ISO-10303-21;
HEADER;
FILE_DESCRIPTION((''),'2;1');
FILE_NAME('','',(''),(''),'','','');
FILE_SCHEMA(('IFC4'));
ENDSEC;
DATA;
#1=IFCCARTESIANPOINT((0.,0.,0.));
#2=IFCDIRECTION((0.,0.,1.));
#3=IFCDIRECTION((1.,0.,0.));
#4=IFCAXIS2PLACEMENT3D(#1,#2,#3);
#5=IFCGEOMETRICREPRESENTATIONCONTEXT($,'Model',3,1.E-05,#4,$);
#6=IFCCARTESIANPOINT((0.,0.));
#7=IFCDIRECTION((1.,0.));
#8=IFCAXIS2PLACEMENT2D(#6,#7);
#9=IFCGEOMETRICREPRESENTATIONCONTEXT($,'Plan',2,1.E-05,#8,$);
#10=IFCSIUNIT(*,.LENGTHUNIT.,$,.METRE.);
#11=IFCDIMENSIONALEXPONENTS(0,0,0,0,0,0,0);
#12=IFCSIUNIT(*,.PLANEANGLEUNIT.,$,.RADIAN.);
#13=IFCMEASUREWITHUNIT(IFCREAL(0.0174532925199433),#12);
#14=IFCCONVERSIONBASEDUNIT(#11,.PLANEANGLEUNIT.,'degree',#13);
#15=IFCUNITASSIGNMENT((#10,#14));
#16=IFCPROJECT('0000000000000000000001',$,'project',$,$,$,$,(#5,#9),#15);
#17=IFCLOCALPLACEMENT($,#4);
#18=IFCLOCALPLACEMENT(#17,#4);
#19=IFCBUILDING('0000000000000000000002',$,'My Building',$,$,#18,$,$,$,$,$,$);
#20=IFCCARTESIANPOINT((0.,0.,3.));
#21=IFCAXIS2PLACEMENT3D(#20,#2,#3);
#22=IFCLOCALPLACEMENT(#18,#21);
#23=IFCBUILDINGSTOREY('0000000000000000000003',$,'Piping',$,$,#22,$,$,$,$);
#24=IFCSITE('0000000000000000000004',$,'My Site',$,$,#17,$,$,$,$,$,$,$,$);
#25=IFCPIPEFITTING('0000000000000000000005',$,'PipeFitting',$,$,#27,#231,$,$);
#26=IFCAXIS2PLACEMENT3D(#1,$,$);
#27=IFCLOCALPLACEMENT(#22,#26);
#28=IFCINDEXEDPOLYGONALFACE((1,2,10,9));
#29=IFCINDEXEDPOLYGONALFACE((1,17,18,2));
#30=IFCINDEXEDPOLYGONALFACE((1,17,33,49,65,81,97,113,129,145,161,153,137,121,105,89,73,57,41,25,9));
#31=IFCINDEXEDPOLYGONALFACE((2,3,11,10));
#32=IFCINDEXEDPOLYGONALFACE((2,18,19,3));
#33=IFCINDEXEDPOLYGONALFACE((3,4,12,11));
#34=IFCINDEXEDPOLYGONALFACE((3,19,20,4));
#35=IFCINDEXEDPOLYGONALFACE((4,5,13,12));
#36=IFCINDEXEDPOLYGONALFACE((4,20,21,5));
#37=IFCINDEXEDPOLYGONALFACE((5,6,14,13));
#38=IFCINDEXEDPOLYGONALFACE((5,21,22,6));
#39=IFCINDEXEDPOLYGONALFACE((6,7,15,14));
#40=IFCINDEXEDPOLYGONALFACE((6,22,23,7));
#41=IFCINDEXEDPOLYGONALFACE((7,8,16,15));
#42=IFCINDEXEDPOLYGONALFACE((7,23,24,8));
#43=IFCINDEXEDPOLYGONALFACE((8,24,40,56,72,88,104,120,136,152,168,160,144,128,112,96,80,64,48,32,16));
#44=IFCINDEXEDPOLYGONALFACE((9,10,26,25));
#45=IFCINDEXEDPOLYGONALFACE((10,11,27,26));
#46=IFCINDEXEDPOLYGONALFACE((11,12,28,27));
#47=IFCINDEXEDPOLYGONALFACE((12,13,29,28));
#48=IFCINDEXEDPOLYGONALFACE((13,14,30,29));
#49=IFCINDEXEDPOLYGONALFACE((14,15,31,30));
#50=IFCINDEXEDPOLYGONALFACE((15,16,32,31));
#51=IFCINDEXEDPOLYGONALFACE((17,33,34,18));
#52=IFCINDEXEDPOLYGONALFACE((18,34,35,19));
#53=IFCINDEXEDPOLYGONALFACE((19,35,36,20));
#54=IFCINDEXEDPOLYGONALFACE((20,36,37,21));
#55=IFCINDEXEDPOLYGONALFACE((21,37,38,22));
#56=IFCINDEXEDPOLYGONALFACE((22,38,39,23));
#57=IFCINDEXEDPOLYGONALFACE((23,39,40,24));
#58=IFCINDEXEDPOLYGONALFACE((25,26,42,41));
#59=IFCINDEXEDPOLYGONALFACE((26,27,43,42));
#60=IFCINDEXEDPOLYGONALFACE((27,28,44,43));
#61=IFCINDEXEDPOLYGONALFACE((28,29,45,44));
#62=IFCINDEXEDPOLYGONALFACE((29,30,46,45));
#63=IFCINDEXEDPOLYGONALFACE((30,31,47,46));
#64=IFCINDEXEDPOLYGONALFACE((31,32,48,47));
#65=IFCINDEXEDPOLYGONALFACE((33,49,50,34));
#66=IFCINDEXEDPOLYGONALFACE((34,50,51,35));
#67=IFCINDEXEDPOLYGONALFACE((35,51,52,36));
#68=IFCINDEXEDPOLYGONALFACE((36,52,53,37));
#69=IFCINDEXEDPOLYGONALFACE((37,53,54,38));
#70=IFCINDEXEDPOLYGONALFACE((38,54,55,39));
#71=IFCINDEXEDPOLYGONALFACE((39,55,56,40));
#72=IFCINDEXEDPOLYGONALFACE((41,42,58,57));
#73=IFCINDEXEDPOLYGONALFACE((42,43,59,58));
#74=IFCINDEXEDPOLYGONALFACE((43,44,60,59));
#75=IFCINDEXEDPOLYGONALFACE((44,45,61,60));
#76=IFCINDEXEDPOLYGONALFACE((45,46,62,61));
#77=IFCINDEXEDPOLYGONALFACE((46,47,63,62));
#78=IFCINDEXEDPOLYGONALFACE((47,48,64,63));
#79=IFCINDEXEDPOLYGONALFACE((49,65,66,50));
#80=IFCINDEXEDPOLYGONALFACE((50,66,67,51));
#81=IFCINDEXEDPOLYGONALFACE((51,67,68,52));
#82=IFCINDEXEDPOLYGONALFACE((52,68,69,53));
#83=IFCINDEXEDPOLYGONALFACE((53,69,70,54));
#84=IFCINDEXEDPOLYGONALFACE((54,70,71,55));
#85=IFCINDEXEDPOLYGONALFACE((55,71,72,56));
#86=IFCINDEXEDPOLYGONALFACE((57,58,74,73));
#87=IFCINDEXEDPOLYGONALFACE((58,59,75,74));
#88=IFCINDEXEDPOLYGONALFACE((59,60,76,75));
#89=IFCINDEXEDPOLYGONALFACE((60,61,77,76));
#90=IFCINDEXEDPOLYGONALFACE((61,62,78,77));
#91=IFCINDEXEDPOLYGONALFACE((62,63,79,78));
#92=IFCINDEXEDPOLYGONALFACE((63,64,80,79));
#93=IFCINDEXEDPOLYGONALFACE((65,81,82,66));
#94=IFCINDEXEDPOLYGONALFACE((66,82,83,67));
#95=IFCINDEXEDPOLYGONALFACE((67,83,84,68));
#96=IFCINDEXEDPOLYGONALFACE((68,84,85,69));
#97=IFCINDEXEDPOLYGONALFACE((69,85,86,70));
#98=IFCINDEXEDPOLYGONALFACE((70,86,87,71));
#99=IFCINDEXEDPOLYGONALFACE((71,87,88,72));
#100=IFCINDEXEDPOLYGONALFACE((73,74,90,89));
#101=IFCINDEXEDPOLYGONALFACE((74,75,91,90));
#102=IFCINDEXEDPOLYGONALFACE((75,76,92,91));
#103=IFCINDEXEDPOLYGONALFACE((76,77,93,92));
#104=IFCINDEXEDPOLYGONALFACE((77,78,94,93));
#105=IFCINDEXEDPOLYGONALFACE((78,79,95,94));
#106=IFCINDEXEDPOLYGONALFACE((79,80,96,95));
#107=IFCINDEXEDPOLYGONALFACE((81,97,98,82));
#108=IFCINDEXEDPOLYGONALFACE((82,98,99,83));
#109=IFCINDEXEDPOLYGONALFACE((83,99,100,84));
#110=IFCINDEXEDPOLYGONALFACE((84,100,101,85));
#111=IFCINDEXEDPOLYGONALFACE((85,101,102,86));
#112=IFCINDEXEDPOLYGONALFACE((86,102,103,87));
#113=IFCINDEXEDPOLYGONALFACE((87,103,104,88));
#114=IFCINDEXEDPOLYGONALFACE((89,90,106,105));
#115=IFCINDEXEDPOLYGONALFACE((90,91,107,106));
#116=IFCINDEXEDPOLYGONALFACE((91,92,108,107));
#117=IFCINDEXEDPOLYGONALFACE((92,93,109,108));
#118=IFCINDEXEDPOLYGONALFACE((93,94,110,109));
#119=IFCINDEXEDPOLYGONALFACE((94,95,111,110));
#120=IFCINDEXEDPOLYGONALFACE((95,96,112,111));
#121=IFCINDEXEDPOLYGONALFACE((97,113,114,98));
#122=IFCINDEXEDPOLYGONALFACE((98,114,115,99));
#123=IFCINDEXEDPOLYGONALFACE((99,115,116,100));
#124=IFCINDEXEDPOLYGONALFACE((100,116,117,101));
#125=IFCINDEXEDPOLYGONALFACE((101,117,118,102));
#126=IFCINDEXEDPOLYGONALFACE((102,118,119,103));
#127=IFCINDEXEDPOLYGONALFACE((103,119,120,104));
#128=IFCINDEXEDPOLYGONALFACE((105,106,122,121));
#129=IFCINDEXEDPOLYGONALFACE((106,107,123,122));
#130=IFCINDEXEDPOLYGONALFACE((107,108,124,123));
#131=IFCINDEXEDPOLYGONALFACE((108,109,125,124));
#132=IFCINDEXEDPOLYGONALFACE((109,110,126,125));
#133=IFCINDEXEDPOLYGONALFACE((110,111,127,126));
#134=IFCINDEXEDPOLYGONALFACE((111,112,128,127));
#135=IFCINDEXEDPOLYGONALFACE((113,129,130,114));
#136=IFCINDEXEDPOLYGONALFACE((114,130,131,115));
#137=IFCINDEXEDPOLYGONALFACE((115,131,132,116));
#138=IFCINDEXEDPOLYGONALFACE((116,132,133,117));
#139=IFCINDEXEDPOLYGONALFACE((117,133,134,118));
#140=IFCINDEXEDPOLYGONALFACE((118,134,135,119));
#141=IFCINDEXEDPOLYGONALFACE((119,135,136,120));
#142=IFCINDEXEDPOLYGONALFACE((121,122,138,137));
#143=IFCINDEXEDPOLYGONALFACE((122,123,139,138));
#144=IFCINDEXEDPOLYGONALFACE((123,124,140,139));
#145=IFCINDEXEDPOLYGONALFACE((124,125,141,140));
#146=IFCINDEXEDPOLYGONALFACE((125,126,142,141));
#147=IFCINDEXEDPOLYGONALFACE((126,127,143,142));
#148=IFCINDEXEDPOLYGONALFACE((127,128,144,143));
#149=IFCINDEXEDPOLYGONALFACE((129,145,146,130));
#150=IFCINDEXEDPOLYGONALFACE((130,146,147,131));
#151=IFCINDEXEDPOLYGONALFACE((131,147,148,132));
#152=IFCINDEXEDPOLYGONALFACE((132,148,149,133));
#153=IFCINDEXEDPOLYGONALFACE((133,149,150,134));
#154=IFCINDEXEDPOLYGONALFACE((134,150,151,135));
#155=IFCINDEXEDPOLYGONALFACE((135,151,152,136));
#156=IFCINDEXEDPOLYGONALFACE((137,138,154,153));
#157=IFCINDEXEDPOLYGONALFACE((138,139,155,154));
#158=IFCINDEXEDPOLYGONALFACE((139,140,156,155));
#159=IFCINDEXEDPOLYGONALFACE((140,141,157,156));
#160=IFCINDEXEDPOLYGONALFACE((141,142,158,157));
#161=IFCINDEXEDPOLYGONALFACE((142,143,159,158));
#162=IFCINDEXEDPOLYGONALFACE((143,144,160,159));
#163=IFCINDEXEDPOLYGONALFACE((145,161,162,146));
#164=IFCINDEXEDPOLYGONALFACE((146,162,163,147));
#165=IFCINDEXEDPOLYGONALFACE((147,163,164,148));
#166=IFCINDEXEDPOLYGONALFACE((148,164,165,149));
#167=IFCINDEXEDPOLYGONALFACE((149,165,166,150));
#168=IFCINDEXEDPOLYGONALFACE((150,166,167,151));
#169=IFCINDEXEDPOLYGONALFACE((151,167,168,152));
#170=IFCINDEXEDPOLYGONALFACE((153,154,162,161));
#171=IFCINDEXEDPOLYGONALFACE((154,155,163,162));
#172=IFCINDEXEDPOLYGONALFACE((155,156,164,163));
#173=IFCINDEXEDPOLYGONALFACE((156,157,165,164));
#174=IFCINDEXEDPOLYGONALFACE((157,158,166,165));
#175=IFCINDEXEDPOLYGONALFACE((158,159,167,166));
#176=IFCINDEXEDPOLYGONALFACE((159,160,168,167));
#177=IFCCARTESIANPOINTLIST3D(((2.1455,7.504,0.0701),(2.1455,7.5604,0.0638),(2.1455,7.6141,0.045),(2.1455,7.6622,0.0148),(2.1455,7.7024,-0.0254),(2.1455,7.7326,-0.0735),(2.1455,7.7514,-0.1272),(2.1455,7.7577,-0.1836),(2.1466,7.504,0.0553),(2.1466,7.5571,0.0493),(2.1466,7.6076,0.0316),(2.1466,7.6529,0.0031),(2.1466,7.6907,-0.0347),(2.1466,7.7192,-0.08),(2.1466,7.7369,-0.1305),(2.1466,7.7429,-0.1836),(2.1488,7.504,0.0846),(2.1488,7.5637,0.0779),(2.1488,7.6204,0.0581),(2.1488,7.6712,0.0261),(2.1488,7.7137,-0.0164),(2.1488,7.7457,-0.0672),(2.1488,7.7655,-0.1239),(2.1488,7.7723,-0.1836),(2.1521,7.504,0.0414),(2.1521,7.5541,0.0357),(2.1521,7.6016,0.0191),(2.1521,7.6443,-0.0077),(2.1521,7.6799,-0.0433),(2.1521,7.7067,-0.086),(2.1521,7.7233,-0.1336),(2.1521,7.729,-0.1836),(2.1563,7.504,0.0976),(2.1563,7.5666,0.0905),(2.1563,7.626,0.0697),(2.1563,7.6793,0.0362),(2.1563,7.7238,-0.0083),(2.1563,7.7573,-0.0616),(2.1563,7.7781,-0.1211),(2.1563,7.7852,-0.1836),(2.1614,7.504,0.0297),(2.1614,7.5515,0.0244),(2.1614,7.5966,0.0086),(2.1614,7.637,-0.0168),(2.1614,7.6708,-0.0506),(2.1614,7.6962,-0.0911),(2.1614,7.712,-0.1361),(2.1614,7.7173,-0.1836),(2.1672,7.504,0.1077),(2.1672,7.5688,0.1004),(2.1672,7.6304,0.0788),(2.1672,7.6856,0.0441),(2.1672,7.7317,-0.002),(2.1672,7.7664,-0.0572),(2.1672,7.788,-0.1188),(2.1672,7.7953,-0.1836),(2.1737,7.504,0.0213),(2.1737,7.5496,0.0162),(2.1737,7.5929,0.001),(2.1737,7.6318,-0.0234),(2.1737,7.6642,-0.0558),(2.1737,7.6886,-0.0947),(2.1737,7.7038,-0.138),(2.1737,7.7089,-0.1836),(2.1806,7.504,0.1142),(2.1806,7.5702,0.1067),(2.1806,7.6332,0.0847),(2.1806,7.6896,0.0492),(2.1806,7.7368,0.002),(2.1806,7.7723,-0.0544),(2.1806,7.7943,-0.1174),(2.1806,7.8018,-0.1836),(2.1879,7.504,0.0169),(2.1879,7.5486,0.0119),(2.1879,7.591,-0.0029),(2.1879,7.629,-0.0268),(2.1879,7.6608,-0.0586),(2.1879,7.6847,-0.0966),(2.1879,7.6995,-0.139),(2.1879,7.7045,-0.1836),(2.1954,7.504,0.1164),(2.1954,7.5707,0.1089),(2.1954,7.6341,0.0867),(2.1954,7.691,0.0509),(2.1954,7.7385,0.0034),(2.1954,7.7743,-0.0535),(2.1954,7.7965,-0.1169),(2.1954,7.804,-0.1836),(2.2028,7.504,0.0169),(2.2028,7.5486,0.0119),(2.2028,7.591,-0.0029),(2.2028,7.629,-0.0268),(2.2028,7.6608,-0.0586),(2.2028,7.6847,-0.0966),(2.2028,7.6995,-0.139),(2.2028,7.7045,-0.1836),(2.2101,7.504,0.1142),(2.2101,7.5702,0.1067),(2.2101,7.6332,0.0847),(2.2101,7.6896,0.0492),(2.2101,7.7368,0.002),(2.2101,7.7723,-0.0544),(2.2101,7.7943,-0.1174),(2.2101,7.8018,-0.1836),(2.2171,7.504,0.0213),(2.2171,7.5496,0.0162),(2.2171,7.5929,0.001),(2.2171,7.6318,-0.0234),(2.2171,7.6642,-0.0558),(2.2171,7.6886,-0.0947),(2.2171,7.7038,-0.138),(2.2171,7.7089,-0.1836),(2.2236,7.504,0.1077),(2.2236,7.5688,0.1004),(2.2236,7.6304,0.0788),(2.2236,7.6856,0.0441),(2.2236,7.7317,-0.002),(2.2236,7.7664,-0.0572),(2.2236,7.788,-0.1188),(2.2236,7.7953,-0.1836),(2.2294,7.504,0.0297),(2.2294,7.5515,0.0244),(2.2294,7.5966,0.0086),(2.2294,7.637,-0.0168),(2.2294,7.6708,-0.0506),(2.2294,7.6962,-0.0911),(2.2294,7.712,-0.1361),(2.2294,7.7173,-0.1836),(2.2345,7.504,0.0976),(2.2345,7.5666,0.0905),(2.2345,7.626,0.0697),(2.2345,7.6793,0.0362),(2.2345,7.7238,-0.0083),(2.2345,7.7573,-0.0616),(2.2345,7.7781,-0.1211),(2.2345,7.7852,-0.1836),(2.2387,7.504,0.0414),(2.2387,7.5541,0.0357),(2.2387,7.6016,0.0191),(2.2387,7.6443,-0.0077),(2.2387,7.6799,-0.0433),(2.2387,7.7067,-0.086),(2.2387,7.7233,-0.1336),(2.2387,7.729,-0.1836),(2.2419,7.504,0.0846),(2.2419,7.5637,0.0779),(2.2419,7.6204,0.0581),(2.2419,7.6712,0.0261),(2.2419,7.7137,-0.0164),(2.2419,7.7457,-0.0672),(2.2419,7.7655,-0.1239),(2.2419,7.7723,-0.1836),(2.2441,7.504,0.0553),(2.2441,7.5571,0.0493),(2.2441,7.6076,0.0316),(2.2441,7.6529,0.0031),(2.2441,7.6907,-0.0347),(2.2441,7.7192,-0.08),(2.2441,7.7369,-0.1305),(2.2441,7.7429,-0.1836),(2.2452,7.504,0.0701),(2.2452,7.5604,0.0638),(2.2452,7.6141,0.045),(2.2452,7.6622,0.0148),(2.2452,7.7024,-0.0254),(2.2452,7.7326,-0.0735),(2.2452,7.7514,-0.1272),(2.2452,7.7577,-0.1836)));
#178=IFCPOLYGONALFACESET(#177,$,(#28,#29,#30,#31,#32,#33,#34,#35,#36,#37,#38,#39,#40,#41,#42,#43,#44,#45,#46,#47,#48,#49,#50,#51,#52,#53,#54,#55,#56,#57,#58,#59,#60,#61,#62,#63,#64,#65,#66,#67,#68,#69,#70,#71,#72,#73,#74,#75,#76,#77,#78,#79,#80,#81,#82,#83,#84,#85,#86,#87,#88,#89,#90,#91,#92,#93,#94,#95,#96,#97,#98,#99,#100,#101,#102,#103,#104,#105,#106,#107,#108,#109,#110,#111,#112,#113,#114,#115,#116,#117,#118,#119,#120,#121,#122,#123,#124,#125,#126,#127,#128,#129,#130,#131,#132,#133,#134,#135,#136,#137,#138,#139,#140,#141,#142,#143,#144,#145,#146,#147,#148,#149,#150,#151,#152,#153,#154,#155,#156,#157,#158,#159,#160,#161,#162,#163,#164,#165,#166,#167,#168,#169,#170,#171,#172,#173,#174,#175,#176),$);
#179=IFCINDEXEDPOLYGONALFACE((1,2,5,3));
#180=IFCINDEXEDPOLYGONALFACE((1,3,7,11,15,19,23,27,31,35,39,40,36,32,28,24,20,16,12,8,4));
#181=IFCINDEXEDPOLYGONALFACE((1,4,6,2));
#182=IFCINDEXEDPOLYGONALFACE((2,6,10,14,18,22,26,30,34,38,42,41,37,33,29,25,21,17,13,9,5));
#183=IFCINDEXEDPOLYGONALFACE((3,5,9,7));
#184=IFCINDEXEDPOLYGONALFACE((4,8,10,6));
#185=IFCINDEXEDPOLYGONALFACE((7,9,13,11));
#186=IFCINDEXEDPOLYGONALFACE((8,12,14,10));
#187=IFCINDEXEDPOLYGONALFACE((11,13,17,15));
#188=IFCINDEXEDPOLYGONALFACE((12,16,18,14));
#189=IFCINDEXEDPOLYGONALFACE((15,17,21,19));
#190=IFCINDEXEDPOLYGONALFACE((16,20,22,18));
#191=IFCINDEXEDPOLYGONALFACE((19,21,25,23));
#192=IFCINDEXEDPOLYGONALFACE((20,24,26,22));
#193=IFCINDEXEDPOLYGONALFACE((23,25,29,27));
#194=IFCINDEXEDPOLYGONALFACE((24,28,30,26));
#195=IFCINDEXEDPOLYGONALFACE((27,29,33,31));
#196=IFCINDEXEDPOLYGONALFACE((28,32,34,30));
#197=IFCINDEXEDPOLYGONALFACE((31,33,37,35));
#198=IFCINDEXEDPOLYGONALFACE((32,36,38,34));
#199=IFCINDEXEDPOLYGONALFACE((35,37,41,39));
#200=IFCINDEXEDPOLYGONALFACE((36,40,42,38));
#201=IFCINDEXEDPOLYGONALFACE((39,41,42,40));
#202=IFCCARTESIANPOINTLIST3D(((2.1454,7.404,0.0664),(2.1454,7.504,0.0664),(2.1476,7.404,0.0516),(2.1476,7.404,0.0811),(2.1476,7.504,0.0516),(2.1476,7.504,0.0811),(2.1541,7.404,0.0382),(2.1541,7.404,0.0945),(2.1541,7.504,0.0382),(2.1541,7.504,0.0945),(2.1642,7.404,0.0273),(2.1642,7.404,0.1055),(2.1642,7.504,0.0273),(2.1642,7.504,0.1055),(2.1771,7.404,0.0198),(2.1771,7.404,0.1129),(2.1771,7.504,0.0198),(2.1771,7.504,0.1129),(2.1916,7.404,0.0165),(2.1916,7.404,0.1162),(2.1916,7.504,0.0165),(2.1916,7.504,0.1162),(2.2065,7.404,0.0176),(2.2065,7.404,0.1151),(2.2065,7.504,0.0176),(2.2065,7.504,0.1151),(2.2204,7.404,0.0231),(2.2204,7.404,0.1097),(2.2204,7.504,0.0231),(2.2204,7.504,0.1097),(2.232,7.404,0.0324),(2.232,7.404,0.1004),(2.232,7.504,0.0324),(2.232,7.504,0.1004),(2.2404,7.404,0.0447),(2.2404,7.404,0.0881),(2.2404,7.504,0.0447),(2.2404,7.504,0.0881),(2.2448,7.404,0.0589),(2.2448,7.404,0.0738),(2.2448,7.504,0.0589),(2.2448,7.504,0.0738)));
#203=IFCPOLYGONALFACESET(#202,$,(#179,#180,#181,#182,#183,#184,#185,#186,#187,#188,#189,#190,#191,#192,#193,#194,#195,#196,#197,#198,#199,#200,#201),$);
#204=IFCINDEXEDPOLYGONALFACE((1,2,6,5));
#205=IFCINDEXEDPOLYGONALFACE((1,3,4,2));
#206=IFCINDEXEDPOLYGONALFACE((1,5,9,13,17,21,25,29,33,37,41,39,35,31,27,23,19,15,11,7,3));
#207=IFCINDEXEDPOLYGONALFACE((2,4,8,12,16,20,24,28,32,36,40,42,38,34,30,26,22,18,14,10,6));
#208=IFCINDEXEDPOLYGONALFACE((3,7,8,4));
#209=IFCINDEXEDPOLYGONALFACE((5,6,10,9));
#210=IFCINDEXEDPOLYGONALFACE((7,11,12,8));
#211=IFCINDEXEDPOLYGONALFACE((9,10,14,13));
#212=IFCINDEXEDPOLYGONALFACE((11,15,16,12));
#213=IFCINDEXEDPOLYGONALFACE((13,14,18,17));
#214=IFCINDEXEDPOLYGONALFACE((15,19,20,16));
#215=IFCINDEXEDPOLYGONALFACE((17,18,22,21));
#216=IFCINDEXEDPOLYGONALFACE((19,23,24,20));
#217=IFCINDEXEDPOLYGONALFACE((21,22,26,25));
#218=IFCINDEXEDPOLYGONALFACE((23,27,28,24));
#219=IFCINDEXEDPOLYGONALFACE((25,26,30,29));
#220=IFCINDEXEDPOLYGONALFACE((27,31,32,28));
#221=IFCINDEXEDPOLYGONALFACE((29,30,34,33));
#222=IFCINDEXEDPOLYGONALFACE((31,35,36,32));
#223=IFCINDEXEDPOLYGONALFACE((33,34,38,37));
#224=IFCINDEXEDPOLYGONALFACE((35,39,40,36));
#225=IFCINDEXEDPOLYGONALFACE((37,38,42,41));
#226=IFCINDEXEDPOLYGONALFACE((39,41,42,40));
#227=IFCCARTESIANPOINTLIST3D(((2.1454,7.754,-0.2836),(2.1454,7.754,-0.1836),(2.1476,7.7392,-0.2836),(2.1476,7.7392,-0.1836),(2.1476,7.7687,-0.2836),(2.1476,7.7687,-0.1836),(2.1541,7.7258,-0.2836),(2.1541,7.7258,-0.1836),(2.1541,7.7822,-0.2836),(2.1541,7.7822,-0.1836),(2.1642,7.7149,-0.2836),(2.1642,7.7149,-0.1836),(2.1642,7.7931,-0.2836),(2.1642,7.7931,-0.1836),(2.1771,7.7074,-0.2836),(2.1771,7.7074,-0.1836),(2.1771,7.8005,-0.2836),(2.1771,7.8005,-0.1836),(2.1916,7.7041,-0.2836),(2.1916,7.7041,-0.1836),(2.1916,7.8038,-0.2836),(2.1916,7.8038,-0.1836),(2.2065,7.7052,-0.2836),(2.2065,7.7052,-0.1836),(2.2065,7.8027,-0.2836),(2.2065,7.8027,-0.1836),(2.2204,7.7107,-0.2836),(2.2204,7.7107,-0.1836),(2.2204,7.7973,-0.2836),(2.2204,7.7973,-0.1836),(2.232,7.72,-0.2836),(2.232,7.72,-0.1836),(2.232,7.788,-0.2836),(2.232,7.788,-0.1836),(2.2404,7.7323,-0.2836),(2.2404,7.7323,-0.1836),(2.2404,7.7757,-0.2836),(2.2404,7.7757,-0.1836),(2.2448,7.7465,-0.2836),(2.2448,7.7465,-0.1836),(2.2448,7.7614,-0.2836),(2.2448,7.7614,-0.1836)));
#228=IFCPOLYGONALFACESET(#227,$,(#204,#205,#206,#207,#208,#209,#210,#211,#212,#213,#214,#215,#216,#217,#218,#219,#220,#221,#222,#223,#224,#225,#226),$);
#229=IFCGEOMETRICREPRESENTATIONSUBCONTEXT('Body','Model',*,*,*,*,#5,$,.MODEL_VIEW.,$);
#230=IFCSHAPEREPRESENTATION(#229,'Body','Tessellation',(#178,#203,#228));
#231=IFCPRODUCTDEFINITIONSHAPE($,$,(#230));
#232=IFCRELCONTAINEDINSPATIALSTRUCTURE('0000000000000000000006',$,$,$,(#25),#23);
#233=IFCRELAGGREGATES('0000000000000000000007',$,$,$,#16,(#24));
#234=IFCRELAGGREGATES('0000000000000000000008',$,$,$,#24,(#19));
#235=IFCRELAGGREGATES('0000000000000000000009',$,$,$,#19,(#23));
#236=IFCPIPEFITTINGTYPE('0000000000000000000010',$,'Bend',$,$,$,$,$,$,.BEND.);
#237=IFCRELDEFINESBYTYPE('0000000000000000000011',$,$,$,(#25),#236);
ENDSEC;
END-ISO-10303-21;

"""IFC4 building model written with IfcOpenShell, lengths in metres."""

from ifc_helpers import new_model, entity, si_unit, converted_unit, frame, origin_with_axes, origin_2d_with_axis, place, context, subcontext, project, spatial, circle, extrude, source, transform, mapped, type_object, type_shapes, element, save


model = new_model("IFC4")

# Units and contexts
model_context = context("Model", 3, precision=1e-05, world=origin_with_axes())
plan_context = context("Plan", 2, precision=1e-05, world=origin_2d_with_axis())
body_context = subcontext(model_context, "Body", "Model", "MODEL_VIEW")
ifc_project = project(units=[si_unit("LENGTHUNIT", "METRE"), converted_unit("PLANEANGLEUNIT", "degree", entity("IfcReal", 0.0174532925199433), si_unit("PLANEANGLEUNIT", "RADIAN"), dimensions=[0, 0, 0, 0, 0, 0, 0])], contexts=[model_context, plan_context])

# Site, building, storey
site_placement = place(None, origin_with_axes())
site = spatial("IfcSite", under=ifc_project, at=site_placement, Name="My Site")
building_placement = place(site_placement, origin_with_axes())
building = spatial("IfcBuilding", under=site, at=building_placement, Name="My Building")
storey_placement = place(building_placement, frame((0.0, 0.0, 3.0), z_axis=(0.0, 0.0, 1.0), x_axis=(1.0, 0.0, 0.0)))
storey = spatial("IfcBuildingStorey", under=building, at=storey_placement, Name="Piping")

# Pipe fitting
pipe_fitting_type_1 = type_object("IfcPipeFittingType", Name="Bend", PredefinedType="BEND")
shared_shape = source(origin_with_axes(), body_context, "Body", "SolidModel", [
    entity("IfcSweptDiskSolid", entity("IfcIndexedPolyCurve", entity("IfcCartesianPointList3D", [[0.0, 0.0, 0.1], [0.0, -0.0732, 0.2768], [0.0, -0.25, 0.35]]), [entity("IfcArcIndex", [1, 2, 3])]), 0.05),
    extrude(circle(Radius=0.05), origin_with_axes(), (0.0, 0.0, 1.0), 0.1),
    extrude(circle(Radius=0.05), frame((0.0, -0.25, 0.35), z_axis=(0.0, -1.0, -0.000002), x_axis=(1.0, 0.0, 0.0)), (0.0, 0.0, 1.0), 0.1),
])
type_shapes(pipe_fitting_type_1, [shared_shape])
for number, where, z_axis, x_axis, name in (
    (1, (2.1954, 7.404, 0.0664), (0.0, 1.0, 0.000002), (-1.0, 0.0, 0.0), "PipeFitting"),
):
    element("IfcPipeFitting", number, at=place(storey_placement, frame(where, z_axis=z_axis, x_axis=x_axis)), inside=storey, type_object=pipe_fitting_type_1, Name=name, context=body_context, shape_type="MappedRepresentation", body=[
        mapped(shared_shape, transform((0.0, 0.0, 0.0), x_axis=(1.0, 0.0, 0.0), y_axis=(0.0, 1.0, 0.0), z_axis=(0.0, 0.0, 1.0), scale=1.0)),
    ])

save(model, "model.ifc")
